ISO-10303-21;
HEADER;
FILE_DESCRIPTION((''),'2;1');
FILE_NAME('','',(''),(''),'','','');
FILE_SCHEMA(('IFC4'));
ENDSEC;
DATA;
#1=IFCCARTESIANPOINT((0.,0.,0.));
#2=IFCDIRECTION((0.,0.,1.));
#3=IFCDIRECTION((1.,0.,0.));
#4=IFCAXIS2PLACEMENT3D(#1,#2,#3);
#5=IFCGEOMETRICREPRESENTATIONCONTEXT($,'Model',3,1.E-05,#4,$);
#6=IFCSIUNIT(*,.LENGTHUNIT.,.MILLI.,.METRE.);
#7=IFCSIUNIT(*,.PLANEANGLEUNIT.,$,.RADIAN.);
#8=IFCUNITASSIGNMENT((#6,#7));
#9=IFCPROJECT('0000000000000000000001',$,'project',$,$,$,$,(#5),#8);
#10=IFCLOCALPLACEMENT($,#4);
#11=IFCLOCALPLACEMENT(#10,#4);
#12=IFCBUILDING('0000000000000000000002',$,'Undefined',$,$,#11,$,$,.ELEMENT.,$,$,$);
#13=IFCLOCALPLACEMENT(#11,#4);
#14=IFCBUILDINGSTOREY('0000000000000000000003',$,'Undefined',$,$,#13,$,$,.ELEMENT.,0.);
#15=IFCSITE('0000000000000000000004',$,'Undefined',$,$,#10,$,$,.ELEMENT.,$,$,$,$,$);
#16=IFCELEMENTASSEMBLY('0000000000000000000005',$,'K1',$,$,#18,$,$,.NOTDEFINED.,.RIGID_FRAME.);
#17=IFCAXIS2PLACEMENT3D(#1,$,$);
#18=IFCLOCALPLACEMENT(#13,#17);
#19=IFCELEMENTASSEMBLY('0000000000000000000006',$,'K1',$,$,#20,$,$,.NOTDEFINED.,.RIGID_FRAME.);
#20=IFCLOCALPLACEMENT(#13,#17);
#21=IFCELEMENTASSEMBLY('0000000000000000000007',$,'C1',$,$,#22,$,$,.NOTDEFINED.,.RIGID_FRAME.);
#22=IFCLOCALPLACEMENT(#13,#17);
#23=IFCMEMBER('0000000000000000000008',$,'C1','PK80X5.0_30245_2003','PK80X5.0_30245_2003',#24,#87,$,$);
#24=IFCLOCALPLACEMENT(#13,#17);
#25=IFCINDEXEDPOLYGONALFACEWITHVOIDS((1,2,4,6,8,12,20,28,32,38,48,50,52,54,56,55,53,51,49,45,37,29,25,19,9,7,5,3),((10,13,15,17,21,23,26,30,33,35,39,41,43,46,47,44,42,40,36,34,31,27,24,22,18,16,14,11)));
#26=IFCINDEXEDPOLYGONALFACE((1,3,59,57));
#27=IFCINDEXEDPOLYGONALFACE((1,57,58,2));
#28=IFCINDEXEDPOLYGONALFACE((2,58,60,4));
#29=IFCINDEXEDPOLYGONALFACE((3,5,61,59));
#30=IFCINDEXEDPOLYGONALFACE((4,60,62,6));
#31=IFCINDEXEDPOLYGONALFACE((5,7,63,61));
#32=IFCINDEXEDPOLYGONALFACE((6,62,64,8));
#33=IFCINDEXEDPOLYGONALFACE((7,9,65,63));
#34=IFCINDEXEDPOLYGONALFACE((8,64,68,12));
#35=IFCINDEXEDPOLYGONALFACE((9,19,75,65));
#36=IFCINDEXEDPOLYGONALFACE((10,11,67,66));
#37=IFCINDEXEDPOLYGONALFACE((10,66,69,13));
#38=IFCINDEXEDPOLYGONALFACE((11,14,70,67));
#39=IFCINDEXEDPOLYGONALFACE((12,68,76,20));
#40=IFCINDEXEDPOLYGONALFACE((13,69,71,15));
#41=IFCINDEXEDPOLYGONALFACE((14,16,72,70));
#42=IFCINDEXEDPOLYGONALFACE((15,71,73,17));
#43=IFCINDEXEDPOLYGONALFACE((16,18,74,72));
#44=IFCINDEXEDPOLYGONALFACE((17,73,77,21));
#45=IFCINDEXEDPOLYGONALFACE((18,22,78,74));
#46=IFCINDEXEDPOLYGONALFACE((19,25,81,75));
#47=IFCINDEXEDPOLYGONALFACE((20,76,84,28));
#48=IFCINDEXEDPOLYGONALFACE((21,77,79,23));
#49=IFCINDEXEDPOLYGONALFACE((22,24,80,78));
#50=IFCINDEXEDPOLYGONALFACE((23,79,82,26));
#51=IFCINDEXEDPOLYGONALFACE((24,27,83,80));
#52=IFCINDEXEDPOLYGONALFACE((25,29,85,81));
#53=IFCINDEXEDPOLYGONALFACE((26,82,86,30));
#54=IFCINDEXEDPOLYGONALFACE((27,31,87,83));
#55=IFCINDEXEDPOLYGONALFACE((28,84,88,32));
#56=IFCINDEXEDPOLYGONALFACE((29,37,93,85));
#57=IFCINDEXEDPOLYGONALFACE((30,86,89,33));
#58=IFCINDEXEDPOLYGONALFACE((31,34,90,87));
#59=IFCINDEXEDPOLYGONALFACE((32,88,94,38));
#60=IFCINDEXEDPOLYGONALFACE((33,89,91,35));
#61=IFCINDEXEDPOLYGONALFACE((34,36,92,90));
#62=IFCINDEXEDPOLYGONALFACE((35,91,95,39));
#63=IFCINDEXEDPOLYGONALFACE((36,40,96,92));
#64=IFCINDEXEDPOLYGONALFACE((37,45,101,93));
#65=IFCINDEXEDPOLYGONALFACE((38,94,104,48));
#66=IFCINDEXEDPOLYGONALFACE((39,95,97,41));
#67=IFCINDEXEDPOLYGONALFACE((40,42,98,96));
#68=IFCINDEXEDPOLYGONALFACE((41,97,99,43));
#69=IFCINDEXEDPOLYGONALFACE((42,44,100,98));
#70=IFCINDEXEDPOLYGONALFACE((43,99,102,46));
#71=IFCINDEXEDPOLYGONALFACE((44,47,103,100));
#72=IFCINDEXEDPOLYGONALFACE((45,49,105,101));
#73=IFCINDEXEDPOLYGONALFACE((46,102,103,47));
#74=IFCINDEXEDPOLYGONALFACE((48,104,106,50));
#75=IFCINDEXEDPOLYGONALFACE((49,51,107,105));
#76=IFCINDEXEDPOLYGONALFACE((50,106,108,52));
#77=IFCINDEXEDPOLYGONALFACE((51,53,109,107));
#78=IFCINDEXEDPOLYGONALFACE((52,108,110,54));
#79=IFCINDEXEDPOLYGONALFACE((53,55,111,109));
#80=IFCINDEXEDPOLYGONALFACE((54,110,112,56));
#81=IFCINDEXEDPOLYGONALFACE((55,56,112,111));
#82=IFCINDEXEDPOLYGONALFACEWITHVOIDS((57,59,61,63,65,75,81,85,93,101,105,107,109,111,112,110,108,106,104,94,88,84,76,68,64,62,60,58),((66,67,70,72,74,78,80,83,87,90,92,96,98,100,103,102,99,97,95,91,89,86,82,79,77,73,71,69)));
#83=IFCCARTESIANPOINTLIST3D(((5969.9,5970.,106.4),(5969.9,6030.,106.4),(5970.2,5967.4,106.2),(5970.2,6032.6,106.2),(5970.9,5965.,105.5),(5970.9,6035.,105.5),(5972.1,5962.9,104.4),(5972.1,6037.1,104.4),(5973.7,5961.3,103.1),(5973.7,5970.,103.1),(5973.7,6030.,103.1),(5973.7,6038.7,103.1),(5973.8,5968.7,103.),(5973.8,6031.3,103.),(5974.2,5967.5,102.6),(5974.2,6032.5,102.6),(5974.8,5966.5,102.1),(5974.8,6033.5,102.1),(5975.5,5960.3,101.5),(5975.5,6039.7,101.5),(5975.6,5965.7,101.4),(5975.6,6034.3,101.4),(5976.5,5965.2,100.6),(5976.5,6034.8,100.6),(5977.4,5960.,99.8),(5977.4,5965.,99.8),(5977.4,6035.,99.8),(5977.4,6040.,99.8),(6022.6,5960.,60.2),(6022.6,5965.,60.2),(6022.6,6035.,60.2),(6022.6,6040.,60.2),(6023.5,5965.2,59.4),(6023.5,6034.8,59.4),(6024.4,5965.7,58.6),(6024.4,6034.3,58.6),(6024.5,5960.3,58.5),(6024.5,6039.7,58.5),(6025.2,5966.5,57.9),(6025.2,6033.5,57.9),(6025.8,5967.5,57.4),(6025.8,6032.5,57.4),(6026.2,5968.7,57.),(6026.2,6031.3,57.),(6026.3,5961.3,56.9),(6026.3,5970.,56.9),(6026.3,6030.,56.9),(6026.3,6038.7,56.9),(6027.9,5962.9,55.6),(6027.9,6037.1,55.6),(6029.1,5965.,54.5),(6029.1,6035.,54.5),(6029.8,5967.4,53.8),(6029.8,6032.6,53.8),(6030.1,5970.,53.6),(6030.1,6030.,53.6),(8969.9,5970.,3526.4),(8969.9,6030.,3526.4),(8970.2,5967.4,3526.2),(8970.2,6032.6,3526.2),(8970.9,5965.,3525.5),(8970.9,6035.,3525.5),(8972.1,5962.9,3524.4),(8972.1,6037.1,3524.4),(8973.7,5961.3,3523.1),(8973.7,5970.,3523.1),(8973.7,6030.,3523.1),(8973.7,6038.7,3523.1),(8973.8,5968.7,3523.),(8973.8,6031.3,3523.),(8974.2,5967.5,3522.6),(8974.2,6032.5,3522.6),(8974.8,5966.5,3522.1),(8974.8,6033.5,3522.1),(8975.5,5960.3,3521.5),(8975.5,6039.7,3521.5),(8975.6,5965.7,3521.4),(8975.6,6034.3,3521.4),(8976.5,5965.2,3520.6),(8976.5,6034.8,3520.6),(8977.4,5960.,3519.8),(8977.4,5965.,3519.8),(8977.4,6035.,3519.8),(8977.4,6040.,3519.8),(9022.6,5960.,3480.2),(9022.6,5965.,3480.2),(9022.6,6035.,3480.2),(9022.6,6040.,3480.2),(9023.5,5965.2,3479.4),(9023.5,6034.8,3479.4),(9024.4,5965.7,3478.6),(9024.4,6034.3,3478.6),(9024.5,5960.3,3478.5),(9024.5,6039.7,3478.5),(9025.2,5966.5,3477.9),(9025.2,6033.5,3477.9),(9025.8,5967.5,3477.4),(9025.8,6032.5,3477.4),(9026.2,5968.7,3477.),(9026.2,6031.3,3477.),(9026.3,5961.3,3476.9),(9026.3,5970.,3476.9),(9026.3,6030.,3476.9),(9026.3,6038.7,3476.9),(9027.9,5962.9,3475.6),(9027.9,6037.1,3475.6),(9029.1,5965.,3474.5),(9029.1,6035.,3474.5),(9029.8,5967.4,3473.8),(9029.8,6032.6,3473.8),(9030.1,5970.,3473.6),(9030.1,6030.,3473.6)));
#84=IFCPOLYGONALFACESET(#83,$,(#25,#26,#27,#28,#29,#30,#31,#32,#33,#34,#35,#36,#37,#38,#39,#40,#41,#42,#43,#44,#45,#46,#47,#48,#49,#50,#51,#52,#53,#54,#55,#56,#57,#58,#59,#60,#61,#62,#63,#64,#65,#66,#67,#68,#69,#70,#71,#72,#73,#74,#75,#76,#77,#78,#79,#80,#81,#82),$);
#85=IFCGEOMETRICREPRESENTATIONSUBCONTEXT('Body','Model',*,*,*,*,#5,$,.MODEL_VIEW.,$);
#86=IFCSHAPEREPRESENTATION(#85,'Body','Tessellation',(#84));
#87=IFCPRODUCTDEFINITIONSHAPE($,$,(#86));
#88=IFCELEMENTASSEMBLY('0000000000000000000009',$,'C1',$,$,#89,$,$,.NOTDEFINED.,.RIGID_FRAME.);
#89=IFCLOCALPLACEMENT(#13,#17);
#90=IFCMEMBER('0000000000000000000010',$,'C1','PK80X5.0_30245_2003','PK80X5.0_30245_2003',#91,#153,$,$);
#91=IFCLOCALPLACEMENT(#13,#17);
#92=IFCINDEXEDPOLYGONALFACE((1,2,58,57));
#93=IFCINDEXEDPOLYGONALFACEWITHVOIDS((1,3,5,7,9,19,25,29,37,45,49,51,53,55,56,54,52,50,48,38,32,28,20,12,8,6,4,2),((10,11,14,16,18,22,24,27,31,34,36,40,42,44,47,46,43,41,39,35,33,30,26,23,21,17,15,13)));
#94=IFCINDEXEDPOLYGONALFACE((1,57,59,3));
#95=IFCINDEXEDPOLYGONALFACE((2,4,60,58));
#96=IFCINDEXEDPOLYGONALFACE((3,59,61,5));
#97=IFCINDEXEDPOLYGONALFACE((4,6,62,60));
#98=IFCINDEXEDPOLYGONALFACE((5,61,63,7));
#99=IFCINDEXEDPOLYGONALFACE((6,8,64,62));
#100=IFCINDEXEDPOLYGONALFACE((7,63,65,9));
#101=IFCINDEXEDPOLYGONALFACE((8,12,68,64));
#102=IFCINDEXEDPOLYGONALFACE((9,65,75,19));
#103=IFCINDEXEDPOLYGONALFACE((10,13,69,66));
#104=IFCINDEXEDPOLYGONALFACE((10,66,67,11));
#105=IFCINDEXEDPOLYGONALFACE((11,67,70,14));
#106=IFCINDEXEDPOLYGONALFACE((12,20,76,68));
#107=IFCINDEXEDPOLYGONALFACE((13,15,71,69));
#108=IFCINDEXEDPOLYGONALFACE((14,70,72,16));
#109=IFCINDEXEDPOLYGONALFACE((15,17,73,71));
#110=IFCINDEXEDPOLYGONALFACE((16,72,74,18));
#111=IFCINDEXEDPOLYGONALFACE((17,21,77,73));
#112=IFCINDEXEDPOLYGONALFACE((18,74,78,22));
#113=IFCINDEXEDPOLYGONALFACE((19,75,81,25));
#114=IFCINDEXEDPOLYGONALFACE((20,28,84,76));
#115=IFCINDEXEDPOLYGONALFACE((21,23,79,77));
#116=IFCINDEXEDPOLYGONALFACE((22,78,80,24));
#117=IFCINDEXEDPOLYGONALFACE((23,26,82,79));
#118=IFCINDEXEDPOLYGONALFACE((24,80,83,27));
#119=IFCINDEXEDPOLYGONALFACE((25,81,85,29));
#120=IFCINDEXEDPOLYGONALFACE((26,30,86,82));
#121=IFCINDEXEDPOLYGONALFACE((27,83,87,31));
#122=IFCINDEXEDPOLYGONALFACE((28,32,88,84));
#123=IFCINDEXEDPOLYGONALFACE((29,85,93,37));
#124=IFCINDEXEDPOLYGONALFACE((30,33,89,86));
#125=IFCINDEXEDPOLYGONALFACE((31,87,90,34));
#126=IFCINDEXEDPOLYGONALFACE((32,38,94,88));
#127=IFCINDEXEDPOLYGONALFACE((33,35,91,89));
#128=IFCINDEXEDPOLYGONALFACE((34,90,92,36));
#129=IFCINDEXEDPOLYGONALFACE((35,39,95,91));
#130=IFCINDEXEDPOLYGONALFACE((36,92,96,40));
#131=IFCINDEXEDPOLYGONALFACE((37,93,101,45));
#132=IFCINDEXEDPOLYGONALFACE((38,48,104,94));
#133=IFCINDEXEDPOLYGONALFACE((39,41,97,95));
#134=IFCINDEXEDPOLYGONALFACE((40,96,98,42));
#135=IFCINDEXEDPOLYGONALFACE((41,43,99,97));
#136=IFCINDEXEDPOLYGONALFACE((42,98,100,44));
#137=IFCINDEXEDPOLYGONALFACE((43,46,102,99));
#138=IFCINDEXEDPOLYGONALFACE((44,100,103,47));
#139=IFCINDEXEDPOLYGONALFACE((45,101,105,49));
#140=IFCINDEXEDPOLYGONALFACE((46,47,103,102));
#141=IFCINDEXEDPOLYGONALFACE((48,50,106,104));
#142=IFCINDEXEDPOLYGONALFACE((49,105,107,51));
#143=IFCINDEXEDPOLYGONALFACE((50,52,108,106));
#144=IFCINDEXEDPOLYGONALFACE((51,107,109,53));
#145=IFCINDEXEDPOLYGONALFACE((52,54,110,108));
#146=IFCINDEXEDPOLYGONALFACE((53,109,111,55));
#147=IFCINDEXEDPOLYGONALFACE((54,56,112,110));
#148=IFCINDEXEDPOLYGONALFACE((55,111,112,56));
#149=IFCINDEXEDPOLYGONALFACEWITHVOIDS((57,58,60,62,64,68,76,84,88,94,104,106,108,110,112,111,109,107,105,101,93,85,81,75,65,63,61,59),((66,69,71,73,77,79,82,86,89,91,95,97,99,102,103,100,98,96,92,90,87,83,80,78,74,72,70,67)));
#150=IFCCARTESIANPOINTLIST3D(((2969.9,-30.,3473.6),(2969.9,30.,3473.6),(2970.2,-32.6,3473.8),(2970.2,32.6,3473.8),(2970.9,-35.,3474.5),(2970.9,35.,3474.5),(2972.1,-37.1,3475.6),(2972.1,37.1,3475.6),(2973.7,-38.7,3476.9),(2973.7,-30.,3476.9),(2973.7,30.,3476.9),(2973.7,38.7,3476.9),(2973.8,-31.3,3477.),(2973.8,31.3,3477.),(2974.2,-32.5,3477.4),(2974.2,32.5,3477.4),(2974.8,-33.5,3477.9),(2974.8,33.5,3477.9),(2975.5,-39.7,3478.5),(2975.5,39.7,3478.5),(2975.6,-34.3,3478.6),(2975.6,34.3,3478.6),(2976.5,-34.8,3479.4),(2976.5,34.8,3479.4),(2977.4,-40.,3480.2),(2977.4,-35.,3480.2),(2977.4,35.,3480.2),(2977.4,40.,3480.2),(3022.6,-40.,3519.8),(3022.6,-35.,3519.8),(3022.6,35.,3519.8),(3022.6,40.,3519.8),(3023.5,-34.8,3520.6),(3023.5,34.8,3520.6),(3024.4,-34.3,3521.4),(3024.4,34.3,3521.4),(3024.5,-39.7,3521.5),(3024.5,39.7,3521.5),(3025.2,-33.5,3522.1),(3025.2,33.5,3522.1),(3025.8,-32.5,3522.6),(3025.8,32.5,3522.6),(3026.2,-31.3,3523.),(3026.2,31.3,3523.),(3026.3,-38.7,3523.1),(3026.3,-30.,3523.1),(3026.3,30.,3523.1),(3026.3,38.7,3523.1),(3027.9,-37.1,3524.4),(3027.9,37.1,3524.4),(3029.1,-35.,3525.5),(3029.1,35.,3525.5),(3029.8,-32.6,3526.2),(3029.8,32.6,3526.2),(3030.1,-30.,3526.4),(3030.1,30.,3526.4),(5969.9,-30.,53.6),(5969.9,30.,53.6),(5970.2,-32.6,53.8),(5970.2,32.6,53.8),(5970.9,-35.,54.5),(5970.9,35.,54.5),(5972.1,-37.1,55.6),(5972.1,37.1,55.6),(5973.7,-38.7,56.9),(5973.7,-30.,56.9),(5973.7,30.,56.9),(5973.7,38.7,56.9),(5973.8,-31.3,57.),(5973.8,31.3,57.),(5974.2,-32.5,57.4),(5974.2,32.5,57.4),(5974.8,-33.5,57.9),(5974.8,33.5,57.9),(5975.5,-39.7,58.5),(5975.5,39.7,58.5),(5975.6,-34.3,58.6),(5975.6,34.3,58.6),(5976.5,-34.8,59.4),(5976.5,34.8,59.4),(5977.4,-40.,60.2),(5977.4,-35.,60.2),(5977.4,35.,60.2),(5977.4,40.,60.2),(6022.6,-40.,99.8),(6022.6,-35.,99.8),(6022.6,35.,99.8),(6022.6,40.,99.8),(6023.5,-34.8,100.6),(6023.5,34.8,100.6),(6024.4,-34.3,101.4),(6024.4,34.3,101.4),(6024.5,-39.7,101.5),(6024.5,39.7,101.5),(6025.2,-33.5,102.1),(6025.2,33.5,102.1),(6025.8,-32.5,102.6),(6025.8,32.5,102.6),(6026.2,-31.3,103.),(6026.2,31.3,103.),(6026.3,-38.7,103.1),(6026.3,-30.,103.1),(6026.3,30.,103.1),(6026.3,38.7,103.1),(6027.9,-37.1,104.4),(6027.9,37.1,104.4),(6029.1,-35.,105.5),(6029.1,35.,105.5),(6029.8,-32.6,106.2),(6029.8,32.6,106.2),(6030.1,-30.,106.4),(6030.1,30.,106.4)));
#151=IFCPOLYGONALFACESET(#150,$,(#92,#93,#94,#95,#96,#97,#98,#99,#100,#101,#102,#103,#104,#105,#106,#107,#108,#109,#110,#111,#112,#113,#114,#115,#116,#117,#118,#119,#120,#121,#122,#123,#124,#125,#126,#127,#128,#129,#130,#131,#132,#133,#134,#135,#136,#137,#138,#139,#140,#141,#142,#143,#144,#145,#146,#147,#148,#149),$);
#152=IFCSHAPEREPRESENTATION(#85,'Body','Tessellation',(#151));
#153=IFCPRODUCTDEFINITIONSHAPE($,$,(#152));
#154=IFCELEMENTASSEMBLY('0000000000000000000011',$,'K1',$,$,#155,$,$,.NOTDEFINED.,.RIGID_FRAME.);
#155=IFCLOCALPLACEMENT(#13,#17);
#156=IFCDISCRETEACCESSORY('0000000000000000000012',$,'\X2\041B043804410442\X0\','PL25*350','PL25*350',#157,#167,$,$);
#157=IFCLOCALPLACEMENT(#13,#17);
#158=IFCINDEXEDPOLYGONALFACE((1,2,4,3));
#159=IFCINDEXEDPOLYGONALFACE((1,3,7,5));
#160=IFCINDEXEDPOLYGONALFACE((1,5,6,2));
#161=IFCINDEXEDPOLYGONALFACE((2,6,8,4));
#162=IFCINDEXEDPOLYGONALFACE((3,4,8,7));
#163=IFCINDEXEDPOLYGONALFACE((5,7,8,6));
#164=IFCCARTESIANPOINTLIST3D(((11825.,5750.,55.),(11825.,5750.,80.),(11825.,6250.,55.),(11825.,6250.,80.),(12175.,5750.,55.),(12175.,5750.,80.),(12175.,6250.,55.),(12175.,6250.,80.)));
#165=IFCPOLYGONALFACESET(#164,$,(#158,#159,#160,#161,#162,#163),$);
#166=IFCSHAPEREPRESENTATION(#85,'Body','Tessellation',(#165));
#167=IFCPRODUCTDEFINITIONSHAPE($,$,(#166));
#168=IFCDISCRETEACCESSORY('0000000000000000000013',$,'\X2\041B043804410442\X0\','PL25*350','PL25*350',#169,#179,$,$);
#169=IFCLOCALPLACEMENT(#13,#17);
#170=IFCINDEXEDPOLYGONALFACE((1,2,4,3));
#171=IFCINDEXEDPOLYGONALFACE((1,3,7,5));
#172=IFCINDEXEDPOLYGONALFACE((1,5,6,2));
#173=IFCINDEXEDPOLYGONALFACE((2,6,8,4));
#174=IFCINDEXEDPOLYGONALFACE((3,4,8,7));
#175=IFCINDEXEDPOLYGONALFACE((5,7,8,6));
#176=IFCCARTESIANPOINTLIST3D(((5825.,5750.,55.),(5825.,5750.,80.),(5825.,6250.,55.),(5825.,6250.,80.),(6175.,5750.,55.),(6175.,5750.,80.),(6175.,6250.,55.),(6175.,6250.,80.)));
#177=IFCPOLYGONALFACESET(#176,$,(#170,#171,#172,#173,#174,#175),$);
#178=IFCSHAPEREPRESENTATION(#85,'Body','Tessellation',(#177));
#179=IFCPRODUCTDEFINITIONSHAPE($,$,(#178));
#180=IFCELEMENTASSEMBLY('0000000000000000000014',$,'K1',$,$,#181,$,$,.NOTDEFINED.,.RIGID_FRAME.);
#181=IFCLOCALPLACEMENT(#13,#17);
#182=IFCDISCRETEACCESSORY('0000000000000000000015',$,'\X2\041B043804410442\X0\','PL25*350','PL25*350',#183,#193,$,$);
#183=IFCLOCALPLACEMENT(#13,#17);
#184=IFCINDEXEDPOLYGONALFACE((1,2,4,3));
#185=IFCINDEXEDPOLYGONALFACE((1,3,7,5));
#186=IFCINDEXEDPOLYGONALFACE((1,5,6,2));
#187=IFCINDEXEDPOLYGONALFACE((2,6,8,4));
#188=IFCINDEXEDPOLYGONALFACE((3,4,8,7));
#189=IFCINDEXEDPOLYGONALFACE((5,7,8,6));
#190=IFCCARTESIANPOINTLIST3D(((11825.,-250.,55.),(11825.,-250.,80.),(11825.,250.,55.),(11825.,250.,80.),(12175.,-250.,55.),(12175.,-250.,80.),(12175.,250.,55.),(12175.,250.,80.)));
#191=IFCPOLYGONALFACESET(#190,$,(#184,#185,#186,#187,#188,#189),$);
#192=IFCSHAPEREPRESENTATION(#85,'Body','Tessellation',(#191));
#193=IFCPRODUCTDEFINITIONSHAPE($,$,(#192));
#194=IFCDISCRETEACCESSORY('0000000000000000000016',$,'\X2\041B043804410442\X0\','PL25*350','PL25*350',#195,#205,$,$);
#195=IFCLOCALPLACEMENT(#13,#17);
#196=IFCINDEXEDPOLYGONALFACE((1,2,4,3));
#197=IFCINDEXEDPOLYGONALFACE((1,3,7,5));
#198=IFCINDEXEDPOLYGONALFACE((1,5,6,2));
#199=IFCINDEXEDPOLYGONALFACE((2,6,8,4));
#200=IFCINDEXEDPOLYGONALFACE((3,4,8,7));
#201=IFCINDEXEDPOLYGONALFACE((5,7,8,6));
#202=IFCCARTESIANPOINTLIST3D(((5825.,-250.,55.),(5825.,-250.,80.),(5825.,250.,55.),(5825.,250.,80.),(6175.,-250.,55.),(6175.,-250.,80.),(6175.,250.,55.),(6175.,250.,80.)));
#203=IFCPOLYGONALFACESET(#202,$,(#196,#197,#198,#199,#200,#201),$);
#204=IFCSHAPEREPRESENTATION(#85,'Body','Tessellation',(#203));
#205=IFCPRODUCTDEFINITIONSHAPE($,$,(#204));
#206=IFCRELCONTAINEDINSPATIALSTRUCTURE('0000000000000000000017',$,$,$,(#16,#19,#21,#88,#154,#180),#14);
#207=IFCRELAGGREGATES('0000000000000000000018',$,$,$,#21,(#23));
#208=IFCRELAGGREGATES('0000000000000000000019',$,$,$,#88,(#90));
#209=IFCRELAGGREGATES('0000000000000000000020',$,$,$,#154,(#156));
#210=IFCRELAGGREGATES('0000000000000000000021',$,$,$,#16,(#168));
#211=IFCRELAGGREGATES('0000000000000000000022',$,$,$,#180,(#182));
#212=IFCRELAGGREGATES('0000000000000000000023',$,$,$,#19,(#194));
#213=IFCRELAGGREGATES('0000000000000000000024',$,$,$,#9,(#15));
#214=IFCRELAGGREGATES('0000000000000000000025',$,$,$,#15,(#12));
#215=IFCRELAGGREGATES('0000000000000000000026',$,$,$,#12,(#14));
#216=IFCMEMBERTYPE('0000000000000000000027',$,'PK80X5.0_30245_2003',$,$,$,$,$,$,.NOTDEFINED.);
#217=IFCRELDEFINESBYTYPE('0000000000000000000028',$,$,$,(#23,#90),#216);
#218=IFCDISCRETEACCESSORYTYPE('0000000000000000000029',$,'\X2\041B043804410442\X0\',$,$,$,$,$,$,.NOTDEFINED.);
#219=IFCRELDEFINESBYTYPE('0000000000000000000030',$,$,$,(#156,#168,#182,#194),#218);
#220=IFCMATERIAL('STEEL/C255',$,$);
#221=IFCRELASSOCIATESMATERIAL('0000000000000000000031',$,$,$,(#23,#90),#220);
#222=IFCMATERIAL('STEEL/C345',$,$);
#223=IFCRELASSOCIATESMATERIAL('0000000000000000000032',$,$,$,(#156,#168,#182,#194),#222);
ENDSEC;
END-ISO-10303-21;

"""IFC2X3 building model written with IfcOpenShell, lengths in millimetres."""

from ifc_helpers import new_model, si_unit, frame, origin_with_axes, origin_2d_with_axis, place, context, subcontext, project, spatial, polyline, hollow_rectangle, outline, extrude, material, type_object, element, aggregate, save


model = new_model("IFC2X3")

# Units and contexts
model_context = context("Model", 3, precision=1e-05, world=origin_with_axes())
body_context = subcontext(model_context, "Body", "Model", "MODEL_VIEW")
ifc_project = project(units=[si_unit("LENGTHUNIT", "METRE", prefix="MILLI"), si_unit("PLANEANGLEUNIT", "RADIAN")], contexts=[model_context])

# Site, building, storey
site_placement = place(None, origin_with_axes())
site = spatial("IfcSite", under=ifc_project, at=site_placement, Name="Undefined", CompositionType="ELEMENT")
building_placement = place(site_placement, origin_with_axes())
building = spatial("IfcBuilding", under=site, at=building_placement, Name="Undefined", CompositionType="ELEMENT")
storey_placement = place(building_placement, origin_with_axes())
storey = spatial("IfcBuildingStorey", under=building, at=storey_placement, Name="Undefined", CompositionType="ELEMENT", Elevation=0.0)

# Element assemblies
assembly_1_placement = place(storey_placement, origin_with_axes())
assembly_1 = element("IfcElementAssembly", 1, at=assembly_1_placement, inside=storey, Name="K1", AssemblyPlace="NOTDEFINED", PredefinedType="RIGID_FRAME")
ifc_material_1 = material(Name="STEEL/C345")
assembly_2_placement = place(storey_placement, origin_with_axes())
assembly_2 = element("IfcElementAssembly", 2, at=assembly_2_placement, inside=storey, Name="K1", AssemblyPlace="NOTDEFINED", PredefinedType="RIGID_FRAME")

# Element assemblies, members
assembly_3_placement = place(storey_placement, origin_with_axes())
assembly_3 = element("IfcElementAssembly", 3, at=assembly_3_placement, inside=storey, Name="C1", AssemblyPlace="NOTDEFINED", PredefinedType="RIGID_FRAME")
ifc_material_2 = material(Name="STEEL/C255")
member_type = type_object("IfcMemberType", Name="PK80X5.0_30245_2003", PredefinedType="NOTDEFINED")
member_1_placement = place(assembly_3_placement, frame((6000.0, 6000.0, 80.0), z_axis=(0.751759, 0.0, -0.659438), x_axis=(0.659438, 0.0, 0.751759)))
member_1 = element("IfcMember", 4, at=member_1_placement, type_object=member_type, material=ifc_material_2, Name="C1", Description="PK80X5.0_30245_2003", ObjectType="PK80X5.0_30245_2003", context=body_context, shape_type="SweptSolid", body=[
    extrude(hollow_rectangle(XDim=80.0, YDim=80.0, WallThickness=5.0, InnerFilletRadius=5.0, OuterFilletRadius=10.0, at=origin_2d_with_axis()), frame((4549.3, 0.0, 0.0), z_axis=(-1.0, 0.0, 0.0), x_axis=(0.0, -1.0, 0.0)), (0.0, 0.0, 1.0), 4549.3),
])
aggregate(assembly_3, [member_1])
assembly_4_placement = place(storey_placement, origin_with_axes())
assembly_4 = element("IfcElementAssembly", 5, at=assembly_4_placement, inside=storey, Name="C1", AssemblyPlace="NOTDEFINED", PredefinedType="RIGID_FRAME")
member_2_placement = place(assembly_4_placement, frame((6000.0, 0.0, 80.0), z_axis=(-0.751759, 0.0, -0.659438), x_axis=(-0.659438, 0.0, 0.751759)))
member_2 = element("IfcMember", 6, at=member_2_placement, type_object=member_type, material=ifc_material_2, Name="C1", Description="PK80X5.0_30245_2003", ObjectType="PK80X5.0_30245_2003", context=body_context, shape_type="SweptSolid", body=[
    extrude(hollow_rectangle(XDim=80.0, YDim=80.0, WallThickness=5.0, InnerFilletRadius=5.0, OuterFilletRadius=10.0, at=origin_2d_with_axis()), frame((4549.3, 0.0, 0.0), z_axis=(-1.0, 0.0, 0.0), x_axis=(0.0, -1.0, 0.0)), (0.0, 0.0, 1.0), 4549.3),
])
aggregate(assembly_4, [member_2])

# Element assembly, discrete accessory
assembly_5_placement = place(storey_placement, origin_with_axes())
assembly_5 = element("IfcElementAssembly", 7, at=assembly_5_placement, inside=storey, Name="K1", AssemblyPlace="NOTDEFINED", PredefinedType="RIGID_FRAME")
discrete_accessory_type = type_object("IfcDiscreteAccessoryType", Name="Лист")
discrete_accessory_1_placement = place(assembly_5_placement, frame((11825.0, 6250.0, 67.5), z_axis=(0.0, 0.0, 1.0), x_axis=(0.0, -1.0, 0.0)))
discrete_accessory_1 = element("IfcDiscreteAccessory", 8, at=discrete_accessory_1_placement, type_object=discrete_accessory_type, material=ifc_material_1, Name="Лист", Description="PL25*350", ObjectType="PL25*350", context=body_context, shape_type="SweptSolid", body=[
    extrude(outline(polyline([(0.0, 0.0), (500.0, 0.0), (500.0, 350.0), (0.0, 350.0), (0.0, 0.0)])), frame((0.0, 0.0, -12.5), z_axis=(0.0, 0.0, 1.0), x_axis=(1.0, 0.0, 0.0)), (0.0, 0.0, 1.0), 25.0),
])
aggregate(assembly_5, [discrete_accessory_1])

# Discrete accessory
discrete_accessory_2_placement = place(assembly_1_placement, frame((5825.0, 6250.0, 67.5), z_axis=(0.0, 0.0, 1.0), x_axis=(0.0, -1.0, 0.0)))
discrete_accessory_2 = element("IfcDiscreteAccessory", 9, at=discrete_accessory_2_placement, type_object=discrete_accessory_type, material=ifc_material_1, Name="Лист", Description="PL25*350", ObjectType="PL25*350", context=body_context, shape_type="SweptSolid", body=[
    extrude(outline(polyline([(0.0, 0.0), (500.0, 0.0), (500.0, 350.0), (0.0, 350.0), (0.0, 0.0)])), frame((0.0, 0.0, -12.5), z_axis=(0.0, 0.0, 1.0), x_axis=(1.0, 0.0, 0.0)), (0.0, 0.0, 1.0), 25.0),
])
aggregate(assembly_1, [discrete_accessory_2])

# Element assembly, discrete accessory
assembly_6_placement = place(storey_placement, origin_with_axes())
assembly_6 = element("IfcElementAssembly", 10, at=assembly_6_placement, inside=storey, Name="K1", AssemblyPlace="NOTDEFINED", PredefinedType="RIGID_FRAME")
discrete_accessory_3_placement = place(assembly_6_placement, frame((11825.0, 250.0, 67.5), z_axis=(0.0, 0.0, 1.0), x_axis=(0.0, -1.0, 0.0)))
discrete_accessory_3 = element("IfcDiscreteAccessory", 11, at=discrete_accessory_3_placement, type_object=discrete_accessory_type, material=ifc_material_1, Name="Лист", Description="PL25*350", ObjectType="PL25*350", context=body_context, shape_type="SweptSolid", body=[
    extrude(outline(polyline([(0.0, 0.0), (500.0, 0.0), (500.0, 350.0), (0.0, 350.0), (0.0, 0.0)])), frame((0.0, 0.0, -12.5), z_axis=(0.0, 0.0, 1.0), x_axis=(1.0, 0.0, 0.0)), (0.0, 0.0, 1.0), 25.0),
])
aggregate(assembly_6, [discrete_accessory_3])

# Discrete accessory
discrete_accessory_4_placement = place(assembly_2_placement, frame((5825.0, 250.0, 67.5), z_axis=(0.0, 0.0, 1.0), x_axis=(0.0, -1.0, 0.0)))
discrete_accessory_4 = element("IfcDiscreteAccessory", 12, at=discrete_accessory_4_placement, type_object=discrete_accessory_type, material=ifc_material_1, Name="Лист", Description="PL25*350", ObjectType="PL25*350", context=body_context, shape_type="SweptSolid", body=[
    extrude(outline(polyline([(0.0, 0.0), (500.0, 0.0), (500.0, 350.0), (0.0, 350.0), (0.0, 0.0)])), frame((0.0, 0.0, -12.5), z_axis=(0.0, 0.0, 1.0), x_axis=(1.0, 0.0, 0.0)), (0.0, 0.0, 1.0), 25.0),
])
aggregate(assembly_2, [discrete_accessory_4])

save(model, "model.ifc")
